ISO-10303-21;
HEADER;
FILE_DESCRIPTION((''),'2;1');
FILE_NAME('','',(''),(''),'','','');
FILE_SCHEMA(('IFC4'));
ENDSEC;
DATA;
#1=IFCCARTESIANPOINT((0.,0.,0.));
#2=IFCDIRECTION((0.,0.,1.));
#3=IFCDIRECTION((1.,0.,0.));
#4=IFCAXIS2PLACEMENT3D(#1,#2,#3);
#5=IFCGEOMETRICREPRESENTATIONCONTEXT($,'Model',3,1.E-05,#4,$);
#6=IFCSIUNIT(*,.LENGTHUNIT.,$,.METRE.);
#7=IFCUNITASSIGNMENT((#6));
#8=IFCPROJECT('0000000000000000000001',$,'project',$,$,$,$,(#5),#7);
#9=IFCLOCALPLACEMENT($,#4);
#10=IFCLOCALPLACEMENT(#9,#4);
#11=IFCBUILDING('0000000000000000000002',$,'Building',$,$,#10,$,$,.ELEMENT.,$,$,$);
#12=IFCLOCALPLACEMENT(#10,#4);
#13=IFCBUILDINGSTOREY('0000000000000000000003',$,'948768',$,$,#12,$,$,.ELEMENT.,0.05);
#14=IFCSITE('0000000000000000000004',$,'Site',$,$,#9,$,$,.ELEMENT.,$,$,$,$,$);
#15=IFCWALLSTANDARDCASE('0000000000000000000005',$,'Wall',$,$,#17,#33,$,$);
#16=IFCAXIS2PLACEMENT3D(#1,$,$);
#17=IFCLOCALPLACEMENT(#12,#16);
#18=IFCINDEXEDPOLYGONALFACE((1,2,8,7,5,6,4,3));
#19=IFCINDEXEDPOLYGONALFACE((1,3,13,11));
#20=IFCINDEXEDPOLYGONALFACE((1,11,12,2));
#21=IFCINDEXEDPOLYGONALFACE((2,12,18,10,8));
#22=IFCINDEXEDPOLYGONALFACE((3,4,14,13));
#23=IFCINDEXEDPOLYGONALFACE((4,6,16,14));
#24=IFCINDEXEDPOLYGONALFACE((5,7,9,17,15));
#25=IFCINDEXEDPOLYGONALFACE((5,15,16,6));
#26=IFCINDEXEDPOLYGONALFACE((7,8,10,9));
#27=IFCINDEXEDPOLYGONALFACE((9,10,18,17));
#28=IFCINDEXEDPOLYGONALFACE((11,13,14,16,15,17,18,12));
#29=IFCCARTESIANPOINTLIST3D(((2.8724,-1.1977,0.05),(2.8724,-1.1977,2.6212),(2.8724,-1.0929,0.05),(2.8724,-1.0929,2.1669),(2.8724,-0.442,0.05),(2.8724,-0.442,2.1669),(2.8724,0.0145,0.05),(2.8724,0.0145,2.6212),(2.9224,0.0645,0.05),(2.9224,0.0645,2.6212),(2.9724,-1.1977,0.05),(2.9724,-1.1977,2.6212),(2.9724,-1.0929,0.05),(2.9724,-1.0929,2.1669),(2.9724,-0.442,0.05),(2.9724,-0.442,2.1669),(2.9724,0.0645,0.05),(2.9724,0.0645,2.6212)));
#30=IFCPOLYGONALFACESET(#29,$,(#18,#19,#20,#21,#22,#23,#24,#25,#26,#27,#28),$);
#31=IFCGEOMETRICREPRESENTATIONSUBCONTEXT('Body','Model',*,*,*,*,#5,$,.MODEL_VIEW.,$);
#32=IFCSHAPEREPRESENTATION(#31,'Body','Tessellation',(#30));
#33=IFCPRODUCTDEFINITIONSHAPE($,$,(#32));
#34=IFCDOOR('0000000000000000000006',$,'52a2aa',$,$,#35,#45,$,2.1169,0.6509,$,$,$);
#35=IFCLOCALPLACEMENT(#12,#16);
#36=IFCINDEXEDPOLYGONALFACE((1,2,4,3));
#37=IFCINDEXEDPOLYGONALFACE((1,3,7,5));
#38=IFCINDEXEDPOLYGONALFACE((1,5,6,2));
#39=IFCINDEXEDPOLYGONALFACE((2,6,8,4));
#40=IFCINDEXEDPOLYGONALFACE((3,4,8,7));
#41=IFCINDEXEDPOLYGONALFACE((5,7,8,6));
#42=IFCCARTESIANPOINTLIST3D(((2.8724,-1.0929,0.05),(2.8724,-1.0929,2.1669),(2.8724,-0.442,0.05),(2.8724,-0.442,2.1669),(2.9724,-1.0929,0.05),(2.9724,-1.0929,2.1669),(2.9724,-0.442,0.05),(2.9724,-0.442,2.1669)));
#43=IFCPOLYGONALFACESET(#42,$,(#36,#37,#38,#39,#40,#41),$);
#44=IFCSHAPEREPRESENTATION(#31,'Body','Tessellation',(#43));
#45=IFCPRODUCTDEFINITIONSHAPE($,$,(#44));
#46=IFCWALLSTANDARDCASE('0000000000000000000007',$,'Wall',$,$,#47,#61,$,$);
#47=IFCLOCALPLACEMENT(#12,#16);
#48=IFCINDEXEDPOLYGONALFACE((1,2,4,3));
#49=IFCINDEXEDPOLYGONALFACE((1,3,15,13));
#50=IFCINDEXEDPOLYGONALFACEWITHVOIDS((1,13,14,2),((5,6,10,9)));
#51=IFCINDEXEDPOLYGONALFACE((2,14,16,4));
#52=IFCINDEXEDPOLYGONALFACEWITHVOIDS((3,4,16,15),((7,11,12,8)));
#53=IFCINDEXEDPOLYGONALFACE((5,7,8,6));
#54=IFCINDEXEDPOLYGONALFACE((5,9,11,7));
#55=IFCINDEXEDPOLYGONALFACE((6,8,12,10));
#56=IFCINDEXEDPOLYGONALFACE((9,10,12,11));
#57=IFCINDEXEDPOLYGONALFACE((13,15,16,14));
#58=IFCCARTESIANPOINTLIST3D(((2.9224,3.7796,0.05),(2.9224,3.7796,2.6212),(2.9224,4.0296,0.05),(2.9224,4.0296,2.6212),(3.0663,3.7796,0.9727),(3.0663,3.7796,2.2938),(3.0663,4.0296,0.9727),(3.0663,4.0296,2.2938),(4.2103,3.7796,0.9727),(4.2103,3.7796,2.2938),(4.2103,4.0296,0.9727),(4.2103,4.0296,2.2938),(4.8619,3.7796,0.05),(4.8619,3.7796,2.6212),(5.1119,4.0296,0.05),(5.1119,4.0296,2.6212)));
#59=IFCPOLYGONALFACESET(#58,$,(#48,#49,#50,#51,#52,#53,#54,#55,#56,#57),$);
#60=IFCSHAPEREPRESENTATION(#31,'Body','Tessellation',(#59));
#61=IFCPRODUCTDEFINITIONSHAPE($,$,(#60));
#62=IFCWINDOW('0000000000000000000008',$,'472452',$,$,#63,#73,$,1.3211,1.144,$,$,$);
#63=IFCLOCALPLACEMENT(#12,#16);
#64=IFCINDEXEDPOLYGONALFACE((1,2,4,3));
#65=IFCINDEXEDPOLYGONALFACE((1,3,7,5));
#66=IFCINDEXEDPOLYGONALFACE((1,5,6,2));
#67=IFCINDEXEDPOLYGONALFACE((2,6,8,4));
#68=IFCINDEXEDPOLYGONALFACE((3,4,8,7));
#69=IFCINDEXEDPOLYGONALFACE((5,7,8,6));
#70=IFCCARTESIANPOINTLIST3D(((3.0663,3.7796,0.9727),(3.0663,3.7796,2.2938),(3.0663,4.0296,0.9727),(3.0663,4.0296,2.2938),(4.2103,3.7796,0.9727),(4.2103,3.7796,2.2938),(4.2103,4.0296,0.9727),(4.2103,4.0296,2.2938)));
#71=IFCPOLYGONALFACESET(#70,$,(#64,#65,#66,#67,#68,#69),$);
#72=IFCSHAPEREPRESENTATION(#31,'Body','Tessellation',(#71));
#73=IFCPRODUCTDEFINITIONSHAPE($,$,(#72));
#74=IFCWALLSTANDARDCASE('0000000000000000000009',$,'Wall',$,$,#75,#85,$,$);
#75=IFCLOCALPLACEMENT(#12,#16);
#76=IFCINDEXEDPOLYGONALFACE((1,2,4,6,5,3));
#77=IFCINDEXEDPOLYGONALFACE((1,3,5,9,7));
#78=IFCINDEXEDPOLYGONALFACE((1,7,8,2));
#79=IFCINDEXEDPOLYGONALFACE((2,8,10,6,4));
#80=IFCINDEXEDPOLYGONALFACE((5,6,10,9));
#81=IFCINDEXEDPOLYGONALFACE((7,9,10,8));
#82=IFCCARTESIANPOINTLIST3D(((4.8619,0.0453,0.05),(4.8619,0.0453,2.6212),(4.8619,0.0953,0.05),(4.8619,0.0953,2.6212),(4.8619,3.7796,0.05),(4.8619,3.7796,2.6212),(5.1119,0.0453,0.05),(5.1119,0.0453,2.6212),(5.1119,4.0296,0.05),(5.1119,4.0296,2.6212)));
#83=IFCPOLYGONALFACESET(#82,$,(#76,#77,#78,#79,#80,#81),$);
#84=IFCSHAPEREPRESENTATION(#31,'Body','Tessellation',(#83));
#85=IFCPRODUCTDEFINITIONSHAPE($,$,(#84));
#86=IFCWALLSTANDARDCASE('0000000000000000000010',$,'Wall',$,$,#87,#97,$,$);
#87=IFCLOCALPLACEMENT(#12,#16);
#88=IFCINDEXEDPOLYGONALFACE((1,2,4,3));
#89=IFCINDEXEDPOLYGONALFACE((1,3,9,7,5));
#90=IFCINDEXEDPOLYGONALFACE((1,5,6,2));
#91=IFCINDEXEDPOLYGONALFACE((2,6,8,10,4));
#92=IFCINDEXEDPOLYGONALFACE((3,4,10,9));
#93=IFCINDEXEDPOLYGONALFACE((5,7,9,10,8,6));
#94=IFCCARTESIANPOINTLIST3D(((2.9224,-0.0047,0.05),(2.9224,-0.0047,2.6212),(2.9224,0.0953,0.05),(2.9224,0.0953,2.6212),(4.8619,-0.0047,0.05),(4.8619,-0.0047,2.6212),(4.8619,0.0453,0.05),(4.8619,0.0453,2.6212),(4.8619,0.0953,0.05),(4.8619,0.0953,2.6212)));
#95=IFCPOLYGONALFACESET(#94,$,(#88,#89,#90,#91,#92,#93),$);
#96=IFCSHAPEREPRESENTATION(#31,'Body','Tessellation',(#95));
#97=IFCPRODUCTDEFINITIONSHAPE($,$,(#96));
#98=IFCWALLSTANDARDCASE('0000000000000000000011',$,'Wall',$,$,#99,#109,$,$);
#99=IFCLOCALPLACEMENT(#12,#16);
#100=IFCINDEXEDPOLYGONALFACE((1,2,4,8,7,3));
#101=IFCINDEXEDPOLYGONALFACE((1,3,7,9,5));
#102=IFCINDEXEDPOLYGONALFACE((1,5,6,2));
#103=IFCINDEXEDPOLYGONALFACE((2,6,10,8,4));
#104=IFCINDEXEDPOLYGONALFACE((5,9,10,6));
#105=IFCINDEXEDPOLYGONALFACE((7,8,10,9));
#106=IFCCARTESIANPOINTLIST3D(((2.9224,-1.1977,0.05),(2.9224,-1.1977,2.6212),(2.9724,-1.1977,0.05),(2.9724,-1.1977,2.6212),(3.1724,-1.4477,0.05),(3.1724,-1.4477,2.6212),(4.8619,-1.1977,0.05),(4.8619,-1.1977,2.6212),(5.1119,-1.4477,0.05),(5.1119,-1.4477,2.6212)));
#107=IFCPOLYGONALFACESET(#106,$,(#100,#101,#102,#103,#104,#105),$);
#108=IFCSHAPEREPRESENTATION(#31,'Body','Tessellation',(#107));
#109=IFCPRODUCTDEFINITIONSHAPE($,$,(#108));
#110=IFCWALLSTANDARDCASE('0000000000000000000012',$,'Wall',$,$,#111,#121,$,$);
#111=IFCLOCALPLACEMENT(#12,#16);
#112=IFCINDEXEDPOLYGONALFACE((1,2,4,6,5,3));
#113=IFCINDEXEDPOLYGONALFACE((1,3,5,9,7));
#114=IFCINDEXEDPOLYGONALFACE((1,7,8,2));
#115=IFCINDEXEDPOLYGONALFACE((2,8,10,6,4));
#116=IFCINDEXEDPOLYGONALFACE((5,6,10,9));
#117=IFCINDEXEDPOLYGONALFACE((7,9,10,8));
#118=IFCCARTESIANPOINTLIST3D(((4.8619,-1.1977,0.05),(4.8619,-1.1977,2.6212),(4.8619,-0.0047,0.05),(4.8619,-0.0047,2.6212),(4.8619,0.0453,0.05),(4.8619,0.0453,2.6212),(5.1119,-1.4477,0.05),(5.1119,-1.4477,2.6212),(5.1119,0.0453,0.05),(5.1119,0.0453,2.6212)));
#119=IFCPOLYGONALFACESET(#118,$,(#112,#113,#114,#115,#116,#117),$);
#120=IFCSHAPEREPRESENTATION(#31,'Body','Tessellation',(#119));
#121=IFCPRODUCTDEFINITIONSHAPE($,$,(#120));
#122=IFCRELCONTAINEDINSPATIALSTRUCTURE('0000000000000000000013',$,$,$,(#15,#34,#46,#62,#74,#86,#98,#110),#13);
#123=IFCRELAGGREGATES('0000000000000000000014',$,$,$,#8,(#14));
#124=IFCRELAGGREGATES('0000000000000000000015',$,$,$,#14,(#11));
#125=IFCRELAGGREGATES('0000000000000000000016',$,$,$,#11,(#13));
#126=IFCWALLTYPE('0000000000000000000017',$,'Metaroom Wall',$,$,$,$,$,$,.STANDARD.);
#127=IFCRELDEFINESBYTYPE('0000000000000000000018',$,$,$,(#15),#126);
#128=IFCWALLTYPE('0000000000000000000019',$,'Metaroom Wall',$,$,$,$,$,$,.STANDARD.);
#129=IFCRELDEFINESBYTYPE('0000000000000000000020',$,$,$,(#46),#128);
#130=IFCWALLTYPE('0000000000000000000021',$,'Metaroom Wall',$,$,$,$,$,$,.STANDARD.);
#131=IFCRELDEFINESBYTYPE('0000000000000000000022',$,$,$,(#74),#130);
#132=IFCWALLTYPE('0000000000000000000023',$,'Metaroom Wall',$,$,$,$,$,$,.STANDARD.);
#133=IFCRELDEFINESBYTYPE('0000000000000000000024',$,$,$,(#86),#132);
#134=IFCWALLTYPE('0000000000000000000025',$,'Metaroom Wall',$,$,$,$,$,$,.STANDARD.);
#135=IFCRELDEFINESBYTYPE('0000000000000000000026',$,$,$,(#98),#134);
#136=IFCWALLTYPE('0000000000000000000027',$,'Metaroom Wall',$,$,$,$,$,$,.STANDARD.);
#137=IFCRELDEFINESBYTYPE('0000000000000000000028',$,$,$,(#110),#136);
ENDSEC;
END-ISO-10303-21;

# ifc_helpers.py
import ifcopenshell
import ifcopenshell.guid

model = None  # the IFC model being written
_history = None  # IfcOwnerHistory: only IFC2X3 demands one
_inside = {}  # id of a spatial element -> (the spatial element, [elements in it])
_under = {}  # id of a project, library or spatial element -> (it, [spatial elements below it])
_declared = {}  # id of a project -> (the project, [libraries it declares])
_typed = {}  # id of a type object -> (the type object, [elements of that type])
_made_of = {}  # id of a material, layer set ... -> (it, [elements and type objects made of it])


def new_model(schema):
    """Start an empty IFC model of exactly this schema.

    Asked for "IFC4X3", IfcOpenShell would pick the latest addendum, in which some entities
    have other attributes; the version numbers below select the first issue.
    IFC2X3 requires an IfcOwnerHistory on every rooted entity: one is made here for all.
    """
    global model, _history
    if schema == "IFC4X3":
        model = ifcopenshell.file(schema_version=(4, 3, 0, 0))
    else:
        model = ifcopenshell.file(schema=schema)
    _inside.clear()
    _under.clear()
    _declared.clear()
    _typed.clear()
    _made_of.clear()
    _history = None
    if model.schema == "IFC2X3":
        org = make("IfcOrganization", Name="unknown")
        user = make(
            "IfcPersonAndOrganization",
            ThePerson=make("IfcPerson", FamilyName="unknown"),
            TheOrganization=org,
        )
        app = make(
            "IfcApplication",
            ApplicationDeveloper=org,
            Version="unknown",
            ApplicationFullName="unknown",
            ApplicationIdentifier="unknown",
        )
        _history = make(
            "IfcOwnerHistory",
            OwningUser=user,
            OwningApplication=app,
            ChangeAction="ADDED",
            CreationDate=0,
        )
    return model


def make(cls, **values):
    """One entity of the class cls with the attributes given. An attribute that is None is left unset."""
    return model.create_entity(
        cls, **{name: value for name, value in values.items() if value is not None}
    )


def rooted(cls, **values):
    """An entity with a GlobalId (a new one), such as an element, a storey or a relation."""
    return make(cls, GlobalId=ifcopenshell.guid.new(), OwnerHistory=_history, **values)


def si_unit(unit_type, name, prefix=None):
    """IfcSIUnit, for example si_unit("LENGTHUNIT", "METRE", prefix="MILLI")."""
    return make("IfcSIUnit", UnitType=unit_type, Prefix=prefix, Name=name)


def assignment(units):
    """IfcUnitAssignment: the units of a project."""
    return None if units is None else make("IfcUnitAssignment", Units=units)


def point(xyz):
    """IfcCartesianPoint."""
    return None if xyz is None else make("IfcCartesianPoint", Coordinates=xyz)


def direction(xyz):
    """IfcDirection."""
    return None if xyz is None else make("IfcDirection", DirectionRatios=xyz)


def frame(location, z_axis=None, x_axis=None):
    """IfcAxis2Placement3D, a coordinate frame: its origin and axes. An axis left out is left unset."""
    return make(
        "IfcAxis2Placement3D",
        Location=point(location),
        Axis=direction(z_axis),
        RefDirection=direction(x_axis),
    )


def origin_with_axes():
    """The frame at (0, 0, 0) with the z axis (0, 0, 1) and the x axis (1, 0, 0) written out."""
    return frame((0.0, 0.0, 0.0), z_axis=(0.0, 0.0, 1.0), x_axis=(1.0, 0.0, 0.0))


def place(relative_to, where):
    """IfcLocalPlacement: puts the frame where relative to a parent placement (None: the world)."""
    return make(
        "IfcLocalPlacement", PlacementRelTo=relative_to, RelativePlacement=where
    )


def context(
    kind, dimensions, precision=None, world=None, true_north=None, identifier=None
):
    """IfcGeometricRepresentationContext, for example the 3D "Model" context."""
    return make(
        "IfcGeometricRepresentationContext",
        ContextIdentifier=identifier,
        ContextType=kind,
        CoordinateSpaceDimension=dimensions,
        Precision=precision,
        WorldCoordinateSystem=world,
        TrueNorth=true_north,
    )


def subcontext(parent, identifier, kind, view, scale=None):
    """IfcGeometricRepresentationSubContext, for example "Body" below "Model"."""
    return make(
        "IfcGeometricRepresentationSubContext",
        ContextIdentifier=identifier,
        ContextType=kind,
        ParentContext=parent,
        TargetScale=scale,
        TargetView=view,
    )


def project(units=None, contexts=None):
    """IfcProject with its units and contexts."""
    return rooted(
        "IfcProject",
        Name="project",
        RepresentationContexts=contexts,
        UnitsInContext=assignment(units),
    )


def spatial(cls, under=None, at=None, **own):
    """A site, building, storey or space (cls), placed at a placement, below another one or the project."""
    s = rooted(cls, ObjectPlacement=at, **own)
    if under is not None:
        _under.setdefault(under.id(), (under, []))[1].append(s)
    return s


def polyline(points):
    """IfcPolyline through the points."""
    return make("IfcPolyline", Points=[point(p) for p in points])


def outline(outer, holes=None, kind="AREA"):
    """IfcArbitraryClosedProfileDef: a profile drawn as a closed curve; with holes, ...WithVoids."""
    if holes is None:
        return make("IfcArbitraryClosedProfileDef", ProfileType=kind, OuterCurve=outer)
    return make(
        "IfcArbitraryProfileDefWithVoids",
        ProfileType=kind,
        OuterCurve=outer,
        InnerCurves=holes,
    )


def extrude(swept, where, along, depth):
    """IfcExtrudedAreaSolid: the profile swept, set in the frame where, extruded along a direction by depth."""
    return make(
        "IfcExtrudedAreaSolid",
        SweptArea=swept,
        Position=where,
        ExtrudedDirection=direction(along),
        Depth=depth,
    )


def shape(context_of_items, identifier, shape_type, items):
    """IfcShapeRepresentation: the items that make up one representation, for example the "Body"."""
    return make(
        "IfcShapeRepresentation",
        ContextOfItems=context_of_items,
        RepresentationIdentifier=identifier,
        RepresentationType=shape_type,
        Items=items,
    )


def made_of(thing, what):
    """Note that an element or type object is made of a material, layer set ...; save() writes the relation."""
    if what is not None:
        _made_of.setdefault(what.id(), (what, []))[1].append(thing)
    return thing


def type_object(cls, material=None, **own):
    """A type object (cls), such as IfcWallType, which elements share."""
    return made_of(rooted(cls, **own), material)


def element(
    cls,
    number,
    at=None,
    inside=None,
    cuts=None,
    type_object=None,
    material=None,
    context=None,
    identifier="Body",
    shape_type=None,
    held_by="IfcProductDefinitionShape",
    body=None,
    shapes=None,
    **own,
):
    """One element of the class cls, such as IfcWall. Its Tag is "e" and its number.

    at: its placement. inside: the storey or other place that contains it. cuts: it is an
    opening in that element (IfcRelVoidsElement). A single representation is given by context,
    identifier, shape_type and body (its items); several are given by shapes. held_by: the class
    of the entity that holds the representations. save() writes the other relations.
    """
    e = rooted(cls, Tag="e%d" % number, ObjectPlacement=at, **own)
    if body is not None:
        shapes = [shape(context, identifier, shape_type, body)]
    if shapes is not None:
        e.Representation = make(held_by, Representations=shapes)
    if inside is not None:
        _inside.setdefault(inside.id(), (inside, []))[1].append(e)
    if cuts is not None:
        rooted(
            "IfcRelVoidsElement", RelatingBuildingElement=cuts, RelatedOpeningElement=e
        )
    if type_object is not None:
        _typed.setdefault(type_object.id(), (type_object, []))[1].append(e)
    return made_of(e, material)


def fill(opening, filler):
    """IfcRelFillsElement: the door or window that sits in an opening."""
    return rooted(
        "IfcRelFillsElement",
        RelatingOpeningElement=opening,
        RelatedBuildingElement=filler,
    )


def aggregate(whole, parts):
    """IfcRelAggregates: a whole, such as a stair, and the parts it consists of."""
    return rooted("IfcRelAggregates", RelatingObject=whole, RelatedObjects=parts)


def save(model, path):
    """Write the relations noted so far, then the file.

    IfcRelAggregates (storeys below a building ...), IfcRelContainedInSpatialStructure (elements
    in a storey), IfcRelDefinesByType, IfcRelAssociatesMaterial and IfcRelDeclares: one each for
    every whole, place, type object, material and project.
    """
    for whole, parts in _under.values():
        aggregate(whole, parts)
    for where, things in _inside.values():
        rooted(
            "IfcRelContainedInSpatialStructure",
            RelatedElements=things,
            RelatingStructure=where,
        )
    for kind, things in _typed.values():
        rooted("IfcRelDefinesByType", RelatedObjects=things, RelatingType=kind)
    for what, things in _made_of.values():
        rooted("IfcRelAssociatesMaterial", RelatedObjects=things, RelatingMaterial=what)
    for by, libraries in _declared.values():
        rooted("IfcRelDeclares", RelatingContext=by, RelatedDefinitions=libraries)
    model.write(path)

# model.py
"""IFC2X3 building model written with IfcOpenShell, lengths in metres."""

from ifc_helpers import new_model, si_unit, frame, origin_with_axes, place, context, subcontext, project, spatial, polyline, outline, extrude, type_object, element, fill, save


model = new_model("IFC2X3")

# Units and contexts
model_context = context("Model", 3, precision=1e-05, world=origin_with_axes())
body_context = subcontext(model_context, "Body", "Model", "MODEL_VIEW")
ifc_project = project(units=[si_unit("LENGTHUNIT", "METRE")], contexts=[model_context])

# Site, building, storey
site_placement = place(None, origin_with_axes())
site = spatial("IfcSite", under=ifc_project, at=site_placement, Name="Site", CompositionType="ELEMENT")
building_placement = place(site_placement, origin_with_axes())
building = spatial("IfcBuilding", under=site, at=building_placement, Name="Building", CompositionType="ELEMENT")
storey_placement = place(building_placement, frame((0.0, 0.0, 0.0), z_axis=(0.0, 0.0, 1.0), x_axis=(1.0, 0.0, 0.0)))
storey = spatial("IfcBuildingStorey", under=building, at=storey_placement, Name="948768", CompositionType="ELEMENT", Elevation=0.05)

# Wall, opening, door
wall_type_1 = type_object("IfcWallType", Name="Metaroom Wall", PredefinedType="STANDARD")
wall_1_placement = place(storey_placement, frame((2.8724, 0.0145, 0.05), z_axis=(0.0, 0.0, 1.0), x_axis=(1.0, 0.0, 0.0)))
wall_1 = element("IfcWallStandardCase", 1, at=wall_1_placement, inside=storey, type_object=wall_type_1, Name="Wall", context=body_context, shape_type="SweptSolid", body=[
    extrude(outline(polyline([(0.0, 0.0), (0.05, 0.05), (0.1, 0.05), (0.1, -1.2121), (0.05, -1.2121), (0.0, -1.2121), (0.0, 0.0)])), origin_with_axes(), (0.0, 0.0, 1.0), 2.5712),
])
opening_1_placement = place(wall_1_placement, frame((0.0, -0.4565, 0.0), z_axis=(0.0, 0.0, 1.0), x_axis=(0.0, -1.0, 0.0)))
opening_1 = element("IfcOpeningElement", 2, at=opening_1_placement, cuts=wall_1, ObjectType="OPENING", context=body_context, shape_type="SweptSolid", body=[
    extrude(outline(polyline([(0.0, 0.0), (0.6509, 0.0), (0.6509, 2.1169), (0.0, 2.1169), (0.0, 0.0)])), frame((0.0, 0.0, 0.0), z_axis=(0.0, -1.0, 0.0), x_axis=(1.0, 0.0, 0.0)), (0.0, 0.0, -1.0), 0.1001),
])
door_1_placement = place(opening_1_placement, origin_with_axes())
door_1 = element("IfcDoor", 3, at=door_1_placement, inside=storey, Name="52a2aa", OverallHeight=2.1169, OverallWidth=0.6509, context=body_context, shape_type="SweptSolid", body=[
    extrude(outline(polyline([(0.0, 0.0), (-0.6509, 0.0), (-0.6509, 2.1169), (0.0, 2.1169), (0.0, 0.0)])), frame((0.0, 0.1, 0.0), z_axis=(0.0, 1.0, 0.0), x_axis=(-1.0, 0.0, 0.0)), (0.0, 0.0, -1.0), 0.1),
])
fill(opening_1, door_1)

# Wall, opening, window
wall_type_2 = type_object("IfcWallType", Name="Metaroom Wall", PredefinedType="STANDARD")
wall_2_placement = place(storey_placement, frame((2.9224, 4.0296, 0.05), z_axis=(0.0, 0.0, 1.0), x_axis=(1.0, 0.0, 0.0)))
wall_2 = element("IfcWallStandardCase", 4, at=wall_2_placement, inside=storey, type_object=wall_type_2, Name="Wall", context=body_context, shape_type="SweptSolid", body=[
    extrude(outline(polyline([(0.0, 0.0), (2.1895, 0.0), (1.9395, -0.25), (0.05, -0.25), (0.0, -0.25), (0.0, 0.0)])), origin_with_axes(), (0.0, 0.0, 1.0), 2.5712),
])
opening_2_placement = place(wall_2_placement, frame((0.1439, -0.25, 0.9227), z_axis=(0.0, 0.0, 1.0), x_axis=(1.0, 0.0, 0.0)))
opening_2 = element("IfcOpeningElement", 5, at=opening_2_placement, cuts=wall_2, ObjectType="OPENING", context=body_context, shape_type="SweptSolid", body=[
    extrude(outline(polyline([(0.0, 0.0), (1.144, 0.0), (1.144, 1.3211), (0.0, 1.3211), (0.0, 0.0)])), frame((0.0, 0.0, 0.0), z_axis=(0.0, -1.0, 0.0), x_axis=(1.0, 0.0, 0.0)), (0.0, 0.0, -1.0), 0.2501),
])
window_1_placement = place(opening_2_placement, origin_with_axes())
window_1 = element("IfcWindow", 6, at=window_1_placement, inside=storey, Name="472452", OverallHeight=1.3211, OverallWidth=1.144, context=body_context, shape_type="SweptSolid", body=[
    extrude(outline(polyline([(0.0, 0.0), (-1.144, 0.0), (-1.144, 1.3211), (0.0, 1.3211), (0.0, 0.0)])), frame((0.0, 0.25, 0.0), z_axis=(0.0, 1.0, 0.0), x_axis=(-1.0, 0.0, 0.0)), (0.0, 0.0, -1.0), 0.25),
])
fill(opening_2, window_1)

# Walls
wall_type_3 = type_object("IfcWallType", Name="Metaroom Wall", PredefinedType="STANDARD")
wall_3_placement = place(storey_placement, frame((4.8619, 3.7796, 0.05), z_axis=(0.0, 0.0, 1.0), x_axis=(1.0, 0.0, 0.0)))
element("IfcWallStandardCase", 7, at=wall_3_placement, inside=storey, type_object=wall_type_3, Name="Wall", context=body_context, shape_type="SweptSolid", body=[
    extrude(outline(polyline([(0.0, 0.0), (0.25, 0.25), (0.25, -3.7343), (0.0, -3.7343), (0.0, -3.6843), (0.0, 0.0)])), origin_with_axes(), (0.0, 0.0, 1.0), 2.5712),
])
wall_type_4 = type_object("IfcWallType", Name="Metaroom Wall", PredefinedType="STANDARD")
wall_4_placement = place(storey_placement, frame((4.8619, 0.0953, 0.05), z_axis=(0.0, 0.0, 1.0), x_axis=(1.0, 0.0, 0.0)))
element("IfcWallStandardCase", 8, at=wall_4_placement, inside=storey, type_object=wall_type_4, Name="Wall", context=body_context, shape_type="SweptSolid", body=[
    extrude(outline(polyline([(0.0, 0.0), (0.0, -0.05), (0.0, -0.1), (-1.9395, -0.1), (-1.9395, 0.0), (0.0, 0.0)])), origin_with_axes(), (0.0, 0.0, 1.0), 2.5712),
])
wall_type_5 = type_object("IfcWallType", Name="Metaroom Wall", PredefinedType="STANDARD")
wall_5_placement = place(storey_placement, frame((2.9224, -1.1977, 0.05), z_axis=(0.0, 0.0, 1.0), x_axis=(1.0, 0.0, 0.0)))
element("IfcWallStandardCase", 9, at=wall_5_placement, inside=storey, type_object=wall_type_5, Name="Wall", context=body_context, shape_type="SweptSolid", body=[
    extrude(outline(polyline([(0.0, 0.0), (0.05, 0.0), (1.9395, 0.0), (2.1895, -0.25), (0.25, -0.25), (0.0, 0.0)])), origin_with_axes(), (0.0, 0.0, 1.0), 2.5712),
])
wall_type_6 = type_object("IfcWallType", Name="Metaroom Wall", PredefinedType="STANDARD")
wall_6_placement = place(storey_placement, frame((4.8619, -0.0047, 0.05), z_axis=(0.0, 0.0, 1.0), x_axis=(1.0, 0.0, 0.0)))
element("IfcWallStandardCase", 10, at=wall_6_placement, inside=storey, type_object=wall_type_6, Name="Wall", context=body_context, shape_type="SweptSolid", body=[
    extrude(outline(polyline([(0.0, 0.0), (0.0, 0.05), (0.25, 0.05), (0.25, -1.443), (0.0, -1.193), (0.0, 0.0)])), origin_with_axes(), (0.0, 0.0, 1.0), 2.5712),
])

save(model, "model.ifc")
